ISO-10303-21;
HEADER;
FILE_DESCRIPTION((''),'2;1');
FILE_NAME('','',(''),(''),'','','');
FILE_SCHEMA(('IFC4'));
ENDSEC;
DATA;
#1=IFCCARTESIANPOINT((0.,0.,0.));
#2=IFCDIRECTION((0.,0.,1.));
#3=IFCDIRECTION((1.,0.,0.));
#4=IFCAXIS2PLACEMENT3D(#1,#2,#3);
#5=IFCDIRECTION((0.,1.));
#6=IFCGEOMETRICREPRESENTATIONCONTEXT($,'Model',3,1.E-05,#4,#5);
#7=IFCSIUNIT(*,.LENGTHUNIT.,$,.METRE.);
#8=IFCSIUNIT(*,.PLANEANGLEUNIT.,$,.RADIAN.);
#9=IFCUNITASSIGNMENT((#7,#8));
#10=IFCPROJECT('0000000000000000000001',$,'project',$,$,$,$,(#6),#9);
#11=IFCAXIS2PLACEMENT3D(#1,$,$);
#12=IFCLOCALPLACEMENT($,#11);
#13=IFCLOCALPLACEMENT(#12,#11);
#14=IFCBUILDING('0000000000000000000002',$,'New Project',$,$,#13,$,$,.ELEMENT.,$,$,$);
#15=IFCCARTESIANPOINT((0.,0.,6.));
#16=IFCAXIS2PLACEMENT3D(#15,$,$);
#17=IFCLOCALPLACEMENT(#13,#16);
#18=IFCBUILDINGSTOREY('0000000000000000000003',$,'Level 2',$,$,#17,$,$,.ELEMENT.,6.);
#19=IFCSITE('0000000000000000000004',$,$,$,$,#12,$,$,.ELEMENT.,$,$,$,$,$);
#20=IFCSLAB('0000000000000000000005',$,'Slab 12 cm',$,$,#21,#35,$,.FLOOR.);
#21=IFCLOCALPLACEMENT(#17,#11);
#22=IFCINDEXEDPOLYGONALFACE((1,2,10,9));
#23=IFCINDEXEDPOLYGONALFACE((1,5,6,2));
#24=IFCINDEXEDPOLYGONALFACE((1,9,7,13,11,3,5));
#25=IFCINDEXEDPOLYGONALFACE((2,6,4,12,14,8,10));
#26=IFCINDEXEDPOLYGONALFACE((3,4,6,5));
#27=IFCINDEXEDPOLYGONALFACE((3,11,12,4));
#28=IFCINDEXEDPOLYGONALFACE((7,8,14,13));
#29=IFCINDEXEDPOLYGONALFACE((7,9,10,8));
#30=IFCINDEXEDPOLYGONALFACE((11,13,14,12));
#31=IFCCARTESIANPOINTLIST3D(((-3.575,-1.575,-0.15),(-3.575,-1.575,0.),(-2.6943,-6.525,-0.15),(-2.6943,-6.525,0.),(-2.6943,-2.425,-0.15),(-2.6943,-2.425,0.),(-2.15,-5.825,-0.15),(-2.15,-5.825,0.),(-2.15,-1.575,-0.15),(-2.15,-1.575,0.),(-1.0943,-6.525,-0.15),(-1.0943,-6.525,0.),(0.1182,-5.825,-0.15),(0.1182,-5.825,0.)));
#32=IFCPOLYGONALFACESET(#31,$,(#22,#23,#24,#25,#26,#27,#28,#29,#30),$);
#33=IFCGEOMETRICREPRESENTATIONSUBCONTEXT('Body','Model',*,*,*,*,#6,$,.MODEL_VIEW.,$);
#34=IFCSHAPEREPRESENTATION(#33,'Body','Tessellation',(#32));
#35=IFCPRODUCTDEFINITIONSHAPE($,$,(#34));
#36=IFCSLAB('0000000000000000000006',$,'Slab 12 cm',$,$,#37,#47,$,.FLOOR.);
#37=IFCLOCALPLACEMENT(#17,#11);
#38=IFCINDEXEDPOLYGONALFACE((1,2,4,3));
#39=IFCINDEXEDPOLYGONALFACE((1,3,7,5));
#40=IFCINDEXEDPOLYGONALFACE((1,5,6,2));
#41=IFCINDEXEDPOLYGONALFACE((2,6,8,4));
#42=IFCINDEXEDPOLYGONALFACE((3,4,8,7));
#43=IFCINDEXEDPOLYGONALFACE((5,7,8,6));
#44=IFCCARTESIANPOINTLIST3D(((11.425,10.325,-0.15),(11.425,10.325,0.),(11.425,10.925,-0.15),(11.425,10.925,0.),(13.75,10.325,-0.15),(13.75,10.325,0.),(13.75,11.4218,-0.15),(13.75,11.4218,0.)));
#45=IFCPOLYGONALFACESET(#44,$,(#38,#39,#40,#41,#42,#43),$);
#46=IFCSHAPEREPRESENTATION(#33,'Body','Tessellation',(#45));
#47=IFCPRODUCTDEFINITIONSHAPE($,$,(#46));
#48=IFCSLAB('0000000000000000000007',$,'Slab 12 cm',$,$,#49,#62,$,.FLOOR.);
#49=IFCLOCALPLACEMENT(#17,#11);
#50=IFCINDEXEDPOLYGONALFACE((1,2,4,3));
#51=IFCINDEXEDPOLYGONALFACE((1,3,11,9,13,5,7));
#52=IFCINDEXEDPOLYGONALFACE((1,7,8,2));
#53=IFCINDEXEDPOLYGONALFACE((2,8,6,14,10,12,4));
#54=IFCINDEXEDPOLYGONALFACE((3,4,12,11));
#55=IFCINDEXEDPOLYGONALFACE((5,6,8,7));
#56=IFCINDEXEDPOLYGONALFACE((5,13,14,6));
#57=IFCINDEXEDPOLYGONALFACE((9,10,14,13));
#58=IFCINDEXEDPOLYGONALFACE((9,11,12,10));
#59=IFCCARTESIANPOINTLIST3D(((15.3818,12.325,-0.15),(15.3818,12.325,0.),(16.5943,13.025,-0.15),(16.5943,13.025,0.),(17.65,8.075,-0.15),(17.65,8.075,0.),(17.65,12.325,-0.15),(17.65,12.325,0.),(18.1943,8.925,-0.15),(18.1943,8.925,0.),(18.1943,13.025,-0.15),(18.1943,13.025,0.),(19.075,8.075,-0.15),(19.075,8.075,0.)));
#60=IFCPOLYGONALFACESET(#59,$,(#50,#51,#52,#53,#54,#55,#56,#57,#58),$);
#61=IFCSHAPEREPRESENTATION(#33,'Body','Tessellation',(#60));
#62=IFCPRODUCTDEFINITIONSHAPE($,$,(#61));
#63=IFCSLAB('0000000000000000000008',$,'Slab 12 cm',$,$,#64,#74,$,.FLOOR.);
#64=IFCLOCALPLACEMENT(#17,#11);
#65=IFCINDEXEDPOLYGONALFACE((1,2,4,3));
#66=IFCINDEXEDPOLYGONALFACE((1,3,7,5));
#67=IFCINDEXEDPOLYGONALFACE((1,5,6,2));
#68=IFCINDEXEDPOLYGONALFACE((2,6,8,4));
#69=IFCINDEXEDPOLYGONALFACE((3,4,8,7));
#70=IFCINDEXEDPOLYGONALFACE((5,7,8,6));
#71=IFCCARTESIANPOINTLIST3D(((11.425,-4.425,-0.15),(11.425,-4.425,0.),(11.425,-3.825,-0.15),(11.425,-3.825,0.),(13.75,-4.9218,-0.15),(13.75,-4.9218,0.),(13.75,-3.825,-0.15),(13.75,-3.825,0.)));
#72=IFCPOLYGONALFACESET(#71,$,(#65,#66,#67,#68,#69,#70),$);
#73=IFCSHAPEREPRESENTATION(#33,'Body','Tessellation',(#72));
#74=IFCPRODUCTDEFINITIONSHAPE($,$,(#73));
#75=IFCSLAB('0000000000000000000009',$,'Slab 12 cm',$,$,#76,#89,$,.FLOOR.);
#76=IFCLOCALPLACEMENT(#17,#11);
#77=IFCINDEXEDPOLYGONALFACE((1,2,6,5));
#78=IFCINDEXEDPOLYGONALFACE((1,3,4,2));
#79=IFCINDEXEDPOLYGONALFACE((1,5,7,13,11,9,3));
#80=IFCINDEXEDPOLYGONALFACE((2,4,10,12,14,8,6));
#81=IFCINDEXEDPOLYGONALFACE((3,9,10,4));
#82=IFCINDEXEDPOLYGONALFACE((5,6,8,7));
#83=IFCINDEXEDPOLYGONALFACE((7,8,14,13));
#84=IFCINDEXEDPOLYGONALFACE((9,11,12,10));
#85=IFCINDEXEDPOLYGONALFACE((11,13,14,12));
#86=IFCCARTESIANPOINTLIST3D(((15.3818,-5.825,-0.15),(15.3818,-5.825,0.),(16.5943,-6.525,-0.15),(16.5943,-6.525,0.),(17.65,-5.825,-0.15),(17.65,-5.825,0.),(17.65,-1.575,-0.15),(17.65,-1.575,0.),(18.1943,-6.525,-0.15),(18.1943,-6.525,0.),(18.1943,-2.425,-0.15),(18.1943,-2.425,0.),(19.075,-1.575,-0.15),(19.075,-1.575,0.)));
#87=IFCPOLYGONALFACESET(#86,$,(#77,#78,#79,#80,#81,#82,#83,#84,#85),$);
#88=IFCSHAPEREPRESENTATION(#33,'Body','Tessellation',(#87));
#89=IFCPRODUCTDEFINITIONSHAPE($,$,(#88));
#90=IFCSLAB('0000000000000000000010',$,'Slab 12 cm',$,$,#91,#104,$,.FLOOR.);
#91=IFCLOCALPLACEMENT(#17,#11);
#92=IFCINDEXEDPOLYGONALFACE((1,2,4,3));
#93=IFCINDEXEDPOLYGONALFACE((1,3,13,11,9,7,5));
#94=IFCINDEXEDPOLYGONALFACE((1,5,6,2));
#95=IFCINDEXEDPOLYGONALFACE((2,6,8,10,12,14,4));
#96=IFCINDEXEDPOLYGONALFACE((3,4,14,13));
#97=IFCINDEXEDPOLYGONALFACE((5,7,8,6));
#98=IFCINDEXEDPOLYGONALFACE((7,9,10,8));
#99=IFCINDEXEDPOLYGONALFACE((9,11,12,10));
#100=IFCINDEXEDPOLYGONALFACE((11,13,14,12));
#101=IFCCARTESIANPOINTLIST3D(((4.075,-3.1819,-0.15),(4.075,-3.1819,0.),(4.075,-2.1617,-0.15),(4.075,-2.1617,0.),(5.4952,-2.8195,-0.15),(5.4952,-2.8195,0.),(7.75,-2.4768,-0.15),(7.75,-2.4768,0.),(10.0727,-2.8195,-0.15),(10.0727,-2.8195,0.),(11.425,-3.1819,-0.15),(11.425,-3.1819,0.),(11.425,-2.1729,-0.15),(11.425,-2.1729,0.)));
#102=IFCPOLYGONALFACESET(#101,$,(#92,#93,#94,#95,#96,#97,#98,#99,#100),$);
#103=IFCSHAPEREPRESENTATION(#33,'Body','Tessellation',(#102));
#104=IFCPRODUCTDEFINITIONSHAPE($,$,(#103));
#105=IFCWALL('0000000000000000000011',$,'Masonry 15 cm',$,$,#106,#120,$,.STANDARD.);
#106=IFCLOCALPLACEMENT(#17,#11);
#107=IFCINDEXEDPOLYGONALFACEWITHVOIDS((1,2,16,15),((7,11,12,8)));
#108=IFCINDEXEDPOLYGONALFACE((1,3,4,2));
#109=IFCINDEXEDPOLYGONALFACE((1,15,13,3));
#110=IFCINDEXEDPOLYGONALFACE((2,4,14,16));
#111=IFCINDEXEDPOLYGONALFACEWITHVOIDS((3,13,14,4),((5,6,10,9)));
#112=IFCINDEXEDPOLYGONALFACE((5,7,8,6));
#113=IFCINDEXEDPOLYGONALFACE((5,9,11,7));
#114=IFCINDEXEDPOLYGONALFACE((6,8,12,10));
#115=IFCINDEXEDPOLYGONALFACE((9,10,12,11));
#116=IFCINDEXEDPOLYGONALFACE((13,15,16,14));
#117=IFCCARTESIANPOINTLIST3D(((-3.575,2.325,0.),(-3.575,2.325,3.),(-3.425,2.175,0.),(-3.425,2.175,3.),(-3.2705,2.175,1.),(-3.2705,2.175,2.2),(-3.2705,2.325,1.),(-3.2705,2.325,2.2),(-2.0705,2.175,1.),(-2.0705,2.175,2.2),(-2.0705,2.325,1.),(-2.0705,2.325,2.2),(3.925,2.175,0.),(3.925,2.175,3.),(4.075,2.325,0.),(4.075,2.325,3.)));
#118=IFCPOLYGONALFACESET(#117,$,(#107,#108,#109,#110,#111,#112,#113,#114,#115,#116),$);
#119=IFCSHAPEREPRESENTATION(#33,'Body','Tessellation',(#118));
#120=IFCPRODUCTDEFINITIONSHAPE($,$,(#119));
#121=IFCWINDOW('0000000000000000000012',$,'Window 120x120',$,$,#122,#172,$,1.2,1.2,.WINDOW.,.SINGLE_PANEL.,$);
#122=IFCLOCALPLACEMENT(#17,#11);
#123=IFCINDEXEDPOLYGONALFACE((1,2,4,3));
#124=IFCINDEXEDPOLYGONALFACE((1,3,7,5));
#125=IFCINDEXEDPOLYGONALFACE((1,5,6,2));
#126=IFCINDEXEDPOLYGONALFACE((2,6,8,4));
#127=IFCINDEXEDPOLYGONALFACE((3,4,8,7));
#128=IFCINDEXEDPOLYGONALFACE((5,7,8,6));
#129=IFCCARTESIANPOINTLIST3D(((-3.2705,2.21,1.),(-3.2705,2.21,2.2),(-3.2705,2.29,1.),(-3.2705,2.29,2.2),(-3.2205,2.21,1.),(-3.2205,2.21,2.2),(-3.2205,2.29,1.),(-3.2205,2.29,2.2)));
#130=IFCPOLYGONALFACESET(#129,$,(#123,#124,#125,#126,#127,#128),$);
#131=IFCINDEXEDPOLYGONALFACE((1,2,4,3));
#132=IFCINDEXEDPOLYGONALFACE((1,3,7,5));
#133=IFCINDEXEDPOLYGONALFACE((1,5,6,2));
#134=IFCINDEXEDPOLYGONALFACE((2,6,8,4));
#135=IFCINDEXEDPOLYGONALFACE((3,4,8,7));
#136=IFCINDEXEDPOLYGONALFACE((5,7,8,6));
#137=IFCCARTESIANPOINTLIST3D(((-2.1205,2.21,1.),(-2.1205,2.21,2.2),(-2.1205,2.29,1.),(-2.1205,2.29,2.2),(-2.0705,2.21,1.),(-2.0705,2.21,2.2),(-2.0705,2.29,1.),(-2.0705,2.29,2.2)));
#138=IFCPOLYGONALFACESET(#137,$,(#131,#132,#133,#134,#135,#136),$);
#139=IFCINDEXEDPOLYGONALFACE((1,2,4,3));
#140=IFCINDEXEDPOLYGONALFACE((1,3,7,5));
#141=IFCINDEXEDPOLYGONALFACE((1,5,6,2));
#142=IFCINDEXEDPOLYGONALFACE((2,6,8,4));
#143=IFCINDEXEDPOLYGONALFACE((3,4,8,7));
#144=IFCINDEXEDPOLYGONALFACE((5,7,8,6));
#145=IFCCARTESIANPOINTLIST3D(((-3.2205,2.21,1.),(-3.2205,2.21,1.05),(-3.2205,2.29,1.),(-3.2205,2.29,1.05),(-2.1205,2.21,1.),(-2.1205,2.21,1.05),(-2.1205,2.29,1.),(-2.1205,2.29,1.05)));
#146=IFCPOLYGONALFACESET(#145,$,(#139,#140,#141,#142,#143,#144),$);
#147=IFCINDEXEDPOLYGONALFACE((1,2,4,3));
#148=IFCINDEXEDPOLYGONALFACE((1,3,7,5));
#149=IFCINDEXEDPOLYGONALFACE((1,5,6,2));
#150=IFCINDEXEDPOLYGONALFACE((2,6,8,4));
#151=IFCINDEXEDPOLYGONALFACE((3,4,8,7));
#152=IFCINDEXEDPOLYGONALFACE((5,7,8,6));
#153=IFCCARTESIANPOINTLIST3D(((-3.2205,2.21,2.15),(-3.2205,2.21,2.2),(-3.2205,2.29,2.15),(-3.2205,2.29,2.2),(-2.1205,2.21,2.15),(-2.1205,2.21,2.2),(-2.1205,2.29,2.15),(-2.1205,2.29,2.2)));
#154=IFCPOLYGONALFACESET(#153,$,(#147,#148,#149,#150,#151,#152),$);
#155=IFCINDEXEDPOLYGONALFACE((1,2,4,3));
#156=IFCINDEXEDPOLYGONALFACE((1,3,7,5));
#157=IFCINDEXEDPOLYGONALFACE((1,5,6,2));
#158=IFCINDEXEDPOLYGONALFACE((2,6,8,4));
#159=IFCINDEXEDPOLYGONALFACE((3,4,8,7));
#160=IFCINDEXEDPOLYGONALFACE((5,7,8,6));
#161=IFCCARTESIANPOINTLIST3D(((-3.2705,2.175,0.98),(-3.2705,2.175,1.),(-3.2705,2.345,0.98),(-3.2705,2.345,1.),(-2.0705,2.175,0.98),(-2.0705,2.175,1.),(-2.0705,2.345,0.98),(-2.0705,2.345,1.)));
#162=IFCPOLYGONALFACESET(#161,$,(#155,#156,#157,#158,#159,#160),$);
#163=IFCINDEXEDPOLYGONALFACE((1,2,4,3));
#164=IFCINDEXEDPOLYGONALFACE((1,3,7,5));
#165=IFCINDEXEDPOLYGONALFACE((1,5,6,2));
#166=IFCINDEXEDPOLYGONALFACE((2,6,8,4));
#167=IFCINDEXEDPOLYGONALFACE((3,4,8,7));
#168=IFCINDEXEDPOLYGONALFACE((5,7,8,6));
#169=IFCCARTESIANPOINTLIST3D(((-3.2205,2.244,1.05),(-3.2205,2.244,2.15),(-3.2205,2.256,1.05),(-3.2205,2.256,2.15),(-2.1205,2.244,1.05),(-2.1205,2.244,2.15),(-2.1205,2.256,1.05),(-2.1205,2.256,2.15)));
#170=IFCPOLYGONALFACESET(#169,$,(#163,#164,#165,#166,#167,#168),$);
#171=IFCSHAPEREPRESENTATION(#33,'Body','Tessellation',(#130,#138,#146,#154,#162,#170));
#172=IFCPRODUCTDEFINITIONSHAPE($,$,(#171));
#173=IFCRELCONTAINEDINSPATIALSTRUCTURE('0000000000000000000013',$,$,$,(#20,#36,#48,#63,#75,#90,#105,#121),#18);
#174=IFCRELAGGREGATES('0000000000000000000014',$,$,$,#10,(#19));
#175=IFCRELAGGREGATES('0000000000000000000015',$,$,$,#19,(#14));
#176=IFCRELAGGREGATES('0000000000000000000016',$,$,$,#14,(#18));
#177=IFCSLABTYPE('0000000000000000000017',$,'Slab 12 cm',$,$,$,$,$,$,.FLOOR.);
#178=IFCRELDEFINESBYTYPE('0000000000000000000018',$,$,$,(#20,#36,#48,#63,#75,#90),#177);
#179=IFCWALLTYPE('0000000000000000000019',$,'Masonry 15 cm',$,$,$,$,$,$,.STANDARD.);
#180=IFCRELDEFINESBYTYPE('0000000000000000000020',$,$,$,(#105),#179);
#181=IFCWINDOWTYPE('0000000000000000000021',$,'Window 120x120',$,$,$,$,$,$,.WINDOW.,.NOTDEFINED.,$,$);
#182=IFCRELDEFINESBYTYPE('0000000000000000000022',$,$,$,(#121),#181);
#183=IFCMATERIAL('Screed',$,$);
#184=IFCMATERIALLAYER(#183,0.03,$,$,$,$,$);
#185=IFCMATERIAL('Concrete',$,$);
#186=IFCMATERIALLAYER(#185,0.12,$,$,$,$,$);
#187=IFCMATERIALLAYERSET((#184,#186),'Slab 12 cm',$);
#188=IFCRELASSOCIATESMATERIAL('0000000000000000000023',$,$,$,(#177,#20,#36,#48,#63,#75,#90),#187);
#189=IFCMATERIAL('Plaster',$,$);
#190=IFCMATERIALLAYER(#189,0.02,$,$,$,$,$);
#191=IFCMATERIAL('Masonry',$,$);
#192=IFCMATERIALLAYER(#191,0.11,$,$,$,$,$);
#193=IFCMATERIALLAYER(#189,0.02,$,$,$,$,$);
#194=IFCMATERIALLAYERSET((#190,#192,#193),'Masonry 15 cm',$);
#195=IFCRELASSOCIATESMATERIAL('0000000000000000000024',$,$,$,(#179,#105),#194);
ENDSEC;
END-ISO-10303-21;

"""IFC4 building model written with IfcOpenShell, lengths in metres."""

from ifc_helpers import new_model, si_unit, direction, frame, frame_2d, origin, origin_with_axes, place, context, subcontext, project, spatial, polyline, rectangle, outline, extrude, material, layer, layer_set, layer_usage, type_object, element, fill, save


model = new_model("IFC4")

# Units and contexts
model_context = context("Model", 3, precision=1e-05, world=origin_with_axes(), true_north=direction((0.0, 1.0)))
body_context = subcontext(model_context, "Body", "Model", "MODEL_VIEW")
ifc_project = project(units=[si_unit("LENGTHUNIT", "METRE"), si_unit("PLANEANGLEUNIT", "RADIAN")], contexts=[model_context])

# Site, building, storey
site_placement = place(None, origin())
site = spatial("IfcSite", under=ifc_project, at=site_placement, CompositionType="ELEMENT")
building_placement = place(site_placement, origin())
building = spatial("IfcBuilding", under=site, at=building_placement, Name="New Project", CompositionType="ELEMENT")
storey_placement = place(building_placement, frame((0.0, 0.0, 6.0)))
storey = spatial("IfcBuildingStorey", under=building, at=storey_placement, Name="Level 2", CompositionType="ELEMENT", Elevation=6.0)

# Slabs
ifc_material_1 = material(Name="Screed")
ifc_layer_1 = layer(ifc_material_1, 0.03)
ifc_material_2 = material(Name="Concrete")
ifc_layer_2 = layer(ifc_material_2, 0.12)
ifc_layer_set_1 = layer_set([ifc_layer_1, ifc_layer_2], Name="Slab 12 cm")
ifc_layer_usage_1 = layer_usage(ifc_layer_set_1, "AXIS3", "NEGATIVE", 0.15)
slab_type = type_object("IfcSlabType", Name="Slab 12 cm", PredefinedType="FLOOR", material=ifc_layer_set_1)
slab_1_placement = place(storey_placement, frame((0.0, 0.0, -0.15)))
element("IfcSlab", 1, at=slab_1_placement, inside=storey, type_object=slab_type, material=ifc_layer_usage_1, Name="Slab 12 cm", PredefinedType="FLOOR", context=body_context, shape_type="SweptSolid", body=[
    extrude(outline(polyline([(-2.15, -5.825), (-2.15, -1.575), (-3.575, -1.575), (-2.6943, -2.425), (-2.6943, -6.525), (-1.0943, -6.525), (0.1182, -5.825), (-2.15, -5.825)])), origin(), (0.0, 0.0, 1.0), 0.15),
])
slab_2_placement = place(storey_placement, frame((0.0, 0.0, -0.15)))
element("IfcSlab", 2, at=slab_2_placement, inside=storey, type_object=slab_type, material=ifc_layer_usage_1, Name="Slab 12 cm", PredefinedType="FLOOR", context=body_context, shape_type="SweptSolid", body=[
    extrude(outline(polyline([(13.75, 10.325), (13.75, 11.4218), (11.425, 10.925), (11.425, 10.325), (13.75, 10.325)])), origin(), (0.0, 0.0, 1.0), 0.15),
])
slab_3_placement = place(storey_placement, frame((0.0, 0.0, -0.15)))
element("IfcSlab", 3, at=slab_3_placement, inside=storey, type_object=slab_type, material=ifc_layer_usage_1, Name="Slab 12 cm", PredefinedType="FLOOR", context=body_context, shape_type="SweptSolid", body=[
    extrude(outline(polyline([(17.65, 12.325), (17.65, 8.075), (19.075, 8.075), (18.1943, 8.925), (18.1943, 13.025), (16.5943, 13.025), (15.3818, 12.325), (17.65, 12.325)])), origin(), (0.0, 0.0, 1.0), 0.15),
])
slab_4_placement = place(storey_placement, frame((0.0, 0.0, -0.15)))
element("IfcSlab", 4, at=slab_4_placement, inside=storey, type_object=slab_type, material=ifc_layer_usage_1, Name="Slab 12 cm", PredefinedType="FLOOR", context=body_context, shape_type="SweptSolid", body=[
    extrude(outline(polyline([(11.425, -3.825), (11.425, -4.425), (13.75, -4.9218), (13.75, -3.825), (11.425, -3.825)])), origin(), (0.0, 0.0, 1.0), 0.15),
])
slab_5_placement = place(storey_placement, frame((0.0, 0.0, -0.15)))
element("IfcSlab", 5, at=slab_5_placement, inside=storey, type_object=slab_type, material=ifc_layer_usage_1, Name="Slab 12 cm", PredefinedType="FLOOR", context=body_context, shape_type="SweptSolid", body=[
    extrude(outline(polyline([(15.3818, -5.825), (16.5943, -6.525), (18.1943, -6.525), (18.1943, -2.425), (19.075, -1.575), (17.65, -1.575), (17.65, -5.825), (15.3818, -5.825)])), origin(), (0.0, 0.0, 1.0), 0.15),
])
slab_6_placement = place(storey_placement, frame((0.0, 0.0, -0.15)))
element("IfcSlab", 6, at=slab_6_placement, inside=storey, type_object=slab_type, material=ifc_layer_usage_1, Name="Slab 12 cm", PredefinedType="FLOOR", context=body_context, shape_type="SweptSolid", body=[
    extrude(outline(polyline([(4.075, -3.1819), (5.4952, -2.8195), (7.75, -2.4768), (10.0727, -2.8195), (11.425, -3.1819), (11.425, -2.1729), (4.075, -2.1617), (4.075, -3.1819)])), origin(), (0.0, 0.0, 1.0), 0.15),
])

# Wall, opening, window
ifc_material_3 = material(Name="Plaster")
ifc_layer_3 = layer(ifc_material_3, 0.02)
ifc_material_4 = material(Name="Masonry")
ifc_layer_4 = layer(ifc_material_4, 0.11)
ifc_layer_5 = layer(ifc_material_3, 0.02)
ifc_layer_set_2 = layer_set([ifc_layer_3, ifc_layer_4, ifc_layer_5], Name="Masonry 15 cm")
ifc_layer_usage_2 = layer_usage(ifc_layer_set_2, "AXIS2", "NEGATIVE", 0.075)
wall_type = type_object("IfcWallType", Name="Masonry 15 cm", PredefinedType="STANDARD", material=ifc_layer_set_2)
wall_1_placement = place(storey_placement, frame((-3.5, 2.25, 0.0)))
wall_1 = element("IfcWall", 7, at=wall_1_placement, inside=storey, type_object=wall_type, material=ifc_layer_usage_2, Name="Masonry 15 cm", PredefinedType="STANDARD", context=body_context, shape_type="SweptSolid", body=[
    extrude(outline(polyline([(0.075, -0.075), (7.425, -0.075), (7.575, 0.075), (-0.075, 0.075), (0.075, -0.075)])), origin(), (0.0, 0.0, 1.0), 3.0),
])
opening_1_placement = place(wall_1_placement, frame((0.2295, 0.0, 1.0)))
opening_1 = element("IfcOpeningElement", 8, at=opening_1_placement, cuts=wall_1, PredefinedType="OPENING", context=body_context, shape_type="SweptSolid", body=[
    extrude(rectangle(XDim=1.2, YDim=0.25, at=frame_2d((0.6, 0.0))), origin(), (0.0, 0.0, 1.0), 1.2),
])
window_type = type_object("IfcWindowType", Name="Window 120x120", PartitioningType="NOTDEFINED", PredefinedType="WINDOW")
window_1_placement = place(opening_1_placement, origin())
window_1 = element("IfcWindow", 9, at=window_1_placement, inside=storey, type_object=window_type, Name="Window 120x120", OverallHeight=1.2, OverallWidth=1.2, PartitioningType="SINGLE_PANEL", PredefinedType="WINDOW", context=body_context, shape_type="SweptSolid", body=[
    extrude(outline(polyline([(0.0, -0.04), (0.05, -0.04), (0.05, 0.04), (0.0, 0.04), (0.0, -0.04)])), origin(), (0.0, 0.0, 1.0), 1.2),
    extrude(outline(polyline([(1.15, -0.04), (1.2, -0.04), (1.2, 0.04), (1.15, 0.04), (1.15, -0.04)])), origin(), (0.0, 0.0, 1.0), 1.2),
    extrude(outline(polyline([(0.05, -0.04), (1.15, -0.04), (1.15, 0.04), (0.05, 0.04), (0.05, -0.04)])), origin(), (0.0, 0.0, 1.0), 0.05),
    extrude(outline(polyline([(0.05, -0.04), (1.15, -0.04), (1.15, 0.04), (0.05, 0.04), (0.05, -0.04)])), frame((0.0, 0.0, 1.15)), (0.0, 0.0, 1.0), 0.05),
    extrude(outline(polyline([(0.0, -0.075), (1.2, -0.075), (1.2, 0.095), (0.0, 0.095), (0.0, -0.075)])), frame((0.0, 0.0, -0.02)), (0.0, 0.0, 1.0), 0.02),
    extrude(outline(polyline([(0.05, -0.006), (1.15, -0.006), (1.15, 0.006), (0.05, 0.006), (0.05, -0.006)])), frame((0.0, 0.0, 0.05)), (0.0, 0.0, 1.0), 1.1),
])
fill(opening_1, window_1)

save(model, "model.ifc")
